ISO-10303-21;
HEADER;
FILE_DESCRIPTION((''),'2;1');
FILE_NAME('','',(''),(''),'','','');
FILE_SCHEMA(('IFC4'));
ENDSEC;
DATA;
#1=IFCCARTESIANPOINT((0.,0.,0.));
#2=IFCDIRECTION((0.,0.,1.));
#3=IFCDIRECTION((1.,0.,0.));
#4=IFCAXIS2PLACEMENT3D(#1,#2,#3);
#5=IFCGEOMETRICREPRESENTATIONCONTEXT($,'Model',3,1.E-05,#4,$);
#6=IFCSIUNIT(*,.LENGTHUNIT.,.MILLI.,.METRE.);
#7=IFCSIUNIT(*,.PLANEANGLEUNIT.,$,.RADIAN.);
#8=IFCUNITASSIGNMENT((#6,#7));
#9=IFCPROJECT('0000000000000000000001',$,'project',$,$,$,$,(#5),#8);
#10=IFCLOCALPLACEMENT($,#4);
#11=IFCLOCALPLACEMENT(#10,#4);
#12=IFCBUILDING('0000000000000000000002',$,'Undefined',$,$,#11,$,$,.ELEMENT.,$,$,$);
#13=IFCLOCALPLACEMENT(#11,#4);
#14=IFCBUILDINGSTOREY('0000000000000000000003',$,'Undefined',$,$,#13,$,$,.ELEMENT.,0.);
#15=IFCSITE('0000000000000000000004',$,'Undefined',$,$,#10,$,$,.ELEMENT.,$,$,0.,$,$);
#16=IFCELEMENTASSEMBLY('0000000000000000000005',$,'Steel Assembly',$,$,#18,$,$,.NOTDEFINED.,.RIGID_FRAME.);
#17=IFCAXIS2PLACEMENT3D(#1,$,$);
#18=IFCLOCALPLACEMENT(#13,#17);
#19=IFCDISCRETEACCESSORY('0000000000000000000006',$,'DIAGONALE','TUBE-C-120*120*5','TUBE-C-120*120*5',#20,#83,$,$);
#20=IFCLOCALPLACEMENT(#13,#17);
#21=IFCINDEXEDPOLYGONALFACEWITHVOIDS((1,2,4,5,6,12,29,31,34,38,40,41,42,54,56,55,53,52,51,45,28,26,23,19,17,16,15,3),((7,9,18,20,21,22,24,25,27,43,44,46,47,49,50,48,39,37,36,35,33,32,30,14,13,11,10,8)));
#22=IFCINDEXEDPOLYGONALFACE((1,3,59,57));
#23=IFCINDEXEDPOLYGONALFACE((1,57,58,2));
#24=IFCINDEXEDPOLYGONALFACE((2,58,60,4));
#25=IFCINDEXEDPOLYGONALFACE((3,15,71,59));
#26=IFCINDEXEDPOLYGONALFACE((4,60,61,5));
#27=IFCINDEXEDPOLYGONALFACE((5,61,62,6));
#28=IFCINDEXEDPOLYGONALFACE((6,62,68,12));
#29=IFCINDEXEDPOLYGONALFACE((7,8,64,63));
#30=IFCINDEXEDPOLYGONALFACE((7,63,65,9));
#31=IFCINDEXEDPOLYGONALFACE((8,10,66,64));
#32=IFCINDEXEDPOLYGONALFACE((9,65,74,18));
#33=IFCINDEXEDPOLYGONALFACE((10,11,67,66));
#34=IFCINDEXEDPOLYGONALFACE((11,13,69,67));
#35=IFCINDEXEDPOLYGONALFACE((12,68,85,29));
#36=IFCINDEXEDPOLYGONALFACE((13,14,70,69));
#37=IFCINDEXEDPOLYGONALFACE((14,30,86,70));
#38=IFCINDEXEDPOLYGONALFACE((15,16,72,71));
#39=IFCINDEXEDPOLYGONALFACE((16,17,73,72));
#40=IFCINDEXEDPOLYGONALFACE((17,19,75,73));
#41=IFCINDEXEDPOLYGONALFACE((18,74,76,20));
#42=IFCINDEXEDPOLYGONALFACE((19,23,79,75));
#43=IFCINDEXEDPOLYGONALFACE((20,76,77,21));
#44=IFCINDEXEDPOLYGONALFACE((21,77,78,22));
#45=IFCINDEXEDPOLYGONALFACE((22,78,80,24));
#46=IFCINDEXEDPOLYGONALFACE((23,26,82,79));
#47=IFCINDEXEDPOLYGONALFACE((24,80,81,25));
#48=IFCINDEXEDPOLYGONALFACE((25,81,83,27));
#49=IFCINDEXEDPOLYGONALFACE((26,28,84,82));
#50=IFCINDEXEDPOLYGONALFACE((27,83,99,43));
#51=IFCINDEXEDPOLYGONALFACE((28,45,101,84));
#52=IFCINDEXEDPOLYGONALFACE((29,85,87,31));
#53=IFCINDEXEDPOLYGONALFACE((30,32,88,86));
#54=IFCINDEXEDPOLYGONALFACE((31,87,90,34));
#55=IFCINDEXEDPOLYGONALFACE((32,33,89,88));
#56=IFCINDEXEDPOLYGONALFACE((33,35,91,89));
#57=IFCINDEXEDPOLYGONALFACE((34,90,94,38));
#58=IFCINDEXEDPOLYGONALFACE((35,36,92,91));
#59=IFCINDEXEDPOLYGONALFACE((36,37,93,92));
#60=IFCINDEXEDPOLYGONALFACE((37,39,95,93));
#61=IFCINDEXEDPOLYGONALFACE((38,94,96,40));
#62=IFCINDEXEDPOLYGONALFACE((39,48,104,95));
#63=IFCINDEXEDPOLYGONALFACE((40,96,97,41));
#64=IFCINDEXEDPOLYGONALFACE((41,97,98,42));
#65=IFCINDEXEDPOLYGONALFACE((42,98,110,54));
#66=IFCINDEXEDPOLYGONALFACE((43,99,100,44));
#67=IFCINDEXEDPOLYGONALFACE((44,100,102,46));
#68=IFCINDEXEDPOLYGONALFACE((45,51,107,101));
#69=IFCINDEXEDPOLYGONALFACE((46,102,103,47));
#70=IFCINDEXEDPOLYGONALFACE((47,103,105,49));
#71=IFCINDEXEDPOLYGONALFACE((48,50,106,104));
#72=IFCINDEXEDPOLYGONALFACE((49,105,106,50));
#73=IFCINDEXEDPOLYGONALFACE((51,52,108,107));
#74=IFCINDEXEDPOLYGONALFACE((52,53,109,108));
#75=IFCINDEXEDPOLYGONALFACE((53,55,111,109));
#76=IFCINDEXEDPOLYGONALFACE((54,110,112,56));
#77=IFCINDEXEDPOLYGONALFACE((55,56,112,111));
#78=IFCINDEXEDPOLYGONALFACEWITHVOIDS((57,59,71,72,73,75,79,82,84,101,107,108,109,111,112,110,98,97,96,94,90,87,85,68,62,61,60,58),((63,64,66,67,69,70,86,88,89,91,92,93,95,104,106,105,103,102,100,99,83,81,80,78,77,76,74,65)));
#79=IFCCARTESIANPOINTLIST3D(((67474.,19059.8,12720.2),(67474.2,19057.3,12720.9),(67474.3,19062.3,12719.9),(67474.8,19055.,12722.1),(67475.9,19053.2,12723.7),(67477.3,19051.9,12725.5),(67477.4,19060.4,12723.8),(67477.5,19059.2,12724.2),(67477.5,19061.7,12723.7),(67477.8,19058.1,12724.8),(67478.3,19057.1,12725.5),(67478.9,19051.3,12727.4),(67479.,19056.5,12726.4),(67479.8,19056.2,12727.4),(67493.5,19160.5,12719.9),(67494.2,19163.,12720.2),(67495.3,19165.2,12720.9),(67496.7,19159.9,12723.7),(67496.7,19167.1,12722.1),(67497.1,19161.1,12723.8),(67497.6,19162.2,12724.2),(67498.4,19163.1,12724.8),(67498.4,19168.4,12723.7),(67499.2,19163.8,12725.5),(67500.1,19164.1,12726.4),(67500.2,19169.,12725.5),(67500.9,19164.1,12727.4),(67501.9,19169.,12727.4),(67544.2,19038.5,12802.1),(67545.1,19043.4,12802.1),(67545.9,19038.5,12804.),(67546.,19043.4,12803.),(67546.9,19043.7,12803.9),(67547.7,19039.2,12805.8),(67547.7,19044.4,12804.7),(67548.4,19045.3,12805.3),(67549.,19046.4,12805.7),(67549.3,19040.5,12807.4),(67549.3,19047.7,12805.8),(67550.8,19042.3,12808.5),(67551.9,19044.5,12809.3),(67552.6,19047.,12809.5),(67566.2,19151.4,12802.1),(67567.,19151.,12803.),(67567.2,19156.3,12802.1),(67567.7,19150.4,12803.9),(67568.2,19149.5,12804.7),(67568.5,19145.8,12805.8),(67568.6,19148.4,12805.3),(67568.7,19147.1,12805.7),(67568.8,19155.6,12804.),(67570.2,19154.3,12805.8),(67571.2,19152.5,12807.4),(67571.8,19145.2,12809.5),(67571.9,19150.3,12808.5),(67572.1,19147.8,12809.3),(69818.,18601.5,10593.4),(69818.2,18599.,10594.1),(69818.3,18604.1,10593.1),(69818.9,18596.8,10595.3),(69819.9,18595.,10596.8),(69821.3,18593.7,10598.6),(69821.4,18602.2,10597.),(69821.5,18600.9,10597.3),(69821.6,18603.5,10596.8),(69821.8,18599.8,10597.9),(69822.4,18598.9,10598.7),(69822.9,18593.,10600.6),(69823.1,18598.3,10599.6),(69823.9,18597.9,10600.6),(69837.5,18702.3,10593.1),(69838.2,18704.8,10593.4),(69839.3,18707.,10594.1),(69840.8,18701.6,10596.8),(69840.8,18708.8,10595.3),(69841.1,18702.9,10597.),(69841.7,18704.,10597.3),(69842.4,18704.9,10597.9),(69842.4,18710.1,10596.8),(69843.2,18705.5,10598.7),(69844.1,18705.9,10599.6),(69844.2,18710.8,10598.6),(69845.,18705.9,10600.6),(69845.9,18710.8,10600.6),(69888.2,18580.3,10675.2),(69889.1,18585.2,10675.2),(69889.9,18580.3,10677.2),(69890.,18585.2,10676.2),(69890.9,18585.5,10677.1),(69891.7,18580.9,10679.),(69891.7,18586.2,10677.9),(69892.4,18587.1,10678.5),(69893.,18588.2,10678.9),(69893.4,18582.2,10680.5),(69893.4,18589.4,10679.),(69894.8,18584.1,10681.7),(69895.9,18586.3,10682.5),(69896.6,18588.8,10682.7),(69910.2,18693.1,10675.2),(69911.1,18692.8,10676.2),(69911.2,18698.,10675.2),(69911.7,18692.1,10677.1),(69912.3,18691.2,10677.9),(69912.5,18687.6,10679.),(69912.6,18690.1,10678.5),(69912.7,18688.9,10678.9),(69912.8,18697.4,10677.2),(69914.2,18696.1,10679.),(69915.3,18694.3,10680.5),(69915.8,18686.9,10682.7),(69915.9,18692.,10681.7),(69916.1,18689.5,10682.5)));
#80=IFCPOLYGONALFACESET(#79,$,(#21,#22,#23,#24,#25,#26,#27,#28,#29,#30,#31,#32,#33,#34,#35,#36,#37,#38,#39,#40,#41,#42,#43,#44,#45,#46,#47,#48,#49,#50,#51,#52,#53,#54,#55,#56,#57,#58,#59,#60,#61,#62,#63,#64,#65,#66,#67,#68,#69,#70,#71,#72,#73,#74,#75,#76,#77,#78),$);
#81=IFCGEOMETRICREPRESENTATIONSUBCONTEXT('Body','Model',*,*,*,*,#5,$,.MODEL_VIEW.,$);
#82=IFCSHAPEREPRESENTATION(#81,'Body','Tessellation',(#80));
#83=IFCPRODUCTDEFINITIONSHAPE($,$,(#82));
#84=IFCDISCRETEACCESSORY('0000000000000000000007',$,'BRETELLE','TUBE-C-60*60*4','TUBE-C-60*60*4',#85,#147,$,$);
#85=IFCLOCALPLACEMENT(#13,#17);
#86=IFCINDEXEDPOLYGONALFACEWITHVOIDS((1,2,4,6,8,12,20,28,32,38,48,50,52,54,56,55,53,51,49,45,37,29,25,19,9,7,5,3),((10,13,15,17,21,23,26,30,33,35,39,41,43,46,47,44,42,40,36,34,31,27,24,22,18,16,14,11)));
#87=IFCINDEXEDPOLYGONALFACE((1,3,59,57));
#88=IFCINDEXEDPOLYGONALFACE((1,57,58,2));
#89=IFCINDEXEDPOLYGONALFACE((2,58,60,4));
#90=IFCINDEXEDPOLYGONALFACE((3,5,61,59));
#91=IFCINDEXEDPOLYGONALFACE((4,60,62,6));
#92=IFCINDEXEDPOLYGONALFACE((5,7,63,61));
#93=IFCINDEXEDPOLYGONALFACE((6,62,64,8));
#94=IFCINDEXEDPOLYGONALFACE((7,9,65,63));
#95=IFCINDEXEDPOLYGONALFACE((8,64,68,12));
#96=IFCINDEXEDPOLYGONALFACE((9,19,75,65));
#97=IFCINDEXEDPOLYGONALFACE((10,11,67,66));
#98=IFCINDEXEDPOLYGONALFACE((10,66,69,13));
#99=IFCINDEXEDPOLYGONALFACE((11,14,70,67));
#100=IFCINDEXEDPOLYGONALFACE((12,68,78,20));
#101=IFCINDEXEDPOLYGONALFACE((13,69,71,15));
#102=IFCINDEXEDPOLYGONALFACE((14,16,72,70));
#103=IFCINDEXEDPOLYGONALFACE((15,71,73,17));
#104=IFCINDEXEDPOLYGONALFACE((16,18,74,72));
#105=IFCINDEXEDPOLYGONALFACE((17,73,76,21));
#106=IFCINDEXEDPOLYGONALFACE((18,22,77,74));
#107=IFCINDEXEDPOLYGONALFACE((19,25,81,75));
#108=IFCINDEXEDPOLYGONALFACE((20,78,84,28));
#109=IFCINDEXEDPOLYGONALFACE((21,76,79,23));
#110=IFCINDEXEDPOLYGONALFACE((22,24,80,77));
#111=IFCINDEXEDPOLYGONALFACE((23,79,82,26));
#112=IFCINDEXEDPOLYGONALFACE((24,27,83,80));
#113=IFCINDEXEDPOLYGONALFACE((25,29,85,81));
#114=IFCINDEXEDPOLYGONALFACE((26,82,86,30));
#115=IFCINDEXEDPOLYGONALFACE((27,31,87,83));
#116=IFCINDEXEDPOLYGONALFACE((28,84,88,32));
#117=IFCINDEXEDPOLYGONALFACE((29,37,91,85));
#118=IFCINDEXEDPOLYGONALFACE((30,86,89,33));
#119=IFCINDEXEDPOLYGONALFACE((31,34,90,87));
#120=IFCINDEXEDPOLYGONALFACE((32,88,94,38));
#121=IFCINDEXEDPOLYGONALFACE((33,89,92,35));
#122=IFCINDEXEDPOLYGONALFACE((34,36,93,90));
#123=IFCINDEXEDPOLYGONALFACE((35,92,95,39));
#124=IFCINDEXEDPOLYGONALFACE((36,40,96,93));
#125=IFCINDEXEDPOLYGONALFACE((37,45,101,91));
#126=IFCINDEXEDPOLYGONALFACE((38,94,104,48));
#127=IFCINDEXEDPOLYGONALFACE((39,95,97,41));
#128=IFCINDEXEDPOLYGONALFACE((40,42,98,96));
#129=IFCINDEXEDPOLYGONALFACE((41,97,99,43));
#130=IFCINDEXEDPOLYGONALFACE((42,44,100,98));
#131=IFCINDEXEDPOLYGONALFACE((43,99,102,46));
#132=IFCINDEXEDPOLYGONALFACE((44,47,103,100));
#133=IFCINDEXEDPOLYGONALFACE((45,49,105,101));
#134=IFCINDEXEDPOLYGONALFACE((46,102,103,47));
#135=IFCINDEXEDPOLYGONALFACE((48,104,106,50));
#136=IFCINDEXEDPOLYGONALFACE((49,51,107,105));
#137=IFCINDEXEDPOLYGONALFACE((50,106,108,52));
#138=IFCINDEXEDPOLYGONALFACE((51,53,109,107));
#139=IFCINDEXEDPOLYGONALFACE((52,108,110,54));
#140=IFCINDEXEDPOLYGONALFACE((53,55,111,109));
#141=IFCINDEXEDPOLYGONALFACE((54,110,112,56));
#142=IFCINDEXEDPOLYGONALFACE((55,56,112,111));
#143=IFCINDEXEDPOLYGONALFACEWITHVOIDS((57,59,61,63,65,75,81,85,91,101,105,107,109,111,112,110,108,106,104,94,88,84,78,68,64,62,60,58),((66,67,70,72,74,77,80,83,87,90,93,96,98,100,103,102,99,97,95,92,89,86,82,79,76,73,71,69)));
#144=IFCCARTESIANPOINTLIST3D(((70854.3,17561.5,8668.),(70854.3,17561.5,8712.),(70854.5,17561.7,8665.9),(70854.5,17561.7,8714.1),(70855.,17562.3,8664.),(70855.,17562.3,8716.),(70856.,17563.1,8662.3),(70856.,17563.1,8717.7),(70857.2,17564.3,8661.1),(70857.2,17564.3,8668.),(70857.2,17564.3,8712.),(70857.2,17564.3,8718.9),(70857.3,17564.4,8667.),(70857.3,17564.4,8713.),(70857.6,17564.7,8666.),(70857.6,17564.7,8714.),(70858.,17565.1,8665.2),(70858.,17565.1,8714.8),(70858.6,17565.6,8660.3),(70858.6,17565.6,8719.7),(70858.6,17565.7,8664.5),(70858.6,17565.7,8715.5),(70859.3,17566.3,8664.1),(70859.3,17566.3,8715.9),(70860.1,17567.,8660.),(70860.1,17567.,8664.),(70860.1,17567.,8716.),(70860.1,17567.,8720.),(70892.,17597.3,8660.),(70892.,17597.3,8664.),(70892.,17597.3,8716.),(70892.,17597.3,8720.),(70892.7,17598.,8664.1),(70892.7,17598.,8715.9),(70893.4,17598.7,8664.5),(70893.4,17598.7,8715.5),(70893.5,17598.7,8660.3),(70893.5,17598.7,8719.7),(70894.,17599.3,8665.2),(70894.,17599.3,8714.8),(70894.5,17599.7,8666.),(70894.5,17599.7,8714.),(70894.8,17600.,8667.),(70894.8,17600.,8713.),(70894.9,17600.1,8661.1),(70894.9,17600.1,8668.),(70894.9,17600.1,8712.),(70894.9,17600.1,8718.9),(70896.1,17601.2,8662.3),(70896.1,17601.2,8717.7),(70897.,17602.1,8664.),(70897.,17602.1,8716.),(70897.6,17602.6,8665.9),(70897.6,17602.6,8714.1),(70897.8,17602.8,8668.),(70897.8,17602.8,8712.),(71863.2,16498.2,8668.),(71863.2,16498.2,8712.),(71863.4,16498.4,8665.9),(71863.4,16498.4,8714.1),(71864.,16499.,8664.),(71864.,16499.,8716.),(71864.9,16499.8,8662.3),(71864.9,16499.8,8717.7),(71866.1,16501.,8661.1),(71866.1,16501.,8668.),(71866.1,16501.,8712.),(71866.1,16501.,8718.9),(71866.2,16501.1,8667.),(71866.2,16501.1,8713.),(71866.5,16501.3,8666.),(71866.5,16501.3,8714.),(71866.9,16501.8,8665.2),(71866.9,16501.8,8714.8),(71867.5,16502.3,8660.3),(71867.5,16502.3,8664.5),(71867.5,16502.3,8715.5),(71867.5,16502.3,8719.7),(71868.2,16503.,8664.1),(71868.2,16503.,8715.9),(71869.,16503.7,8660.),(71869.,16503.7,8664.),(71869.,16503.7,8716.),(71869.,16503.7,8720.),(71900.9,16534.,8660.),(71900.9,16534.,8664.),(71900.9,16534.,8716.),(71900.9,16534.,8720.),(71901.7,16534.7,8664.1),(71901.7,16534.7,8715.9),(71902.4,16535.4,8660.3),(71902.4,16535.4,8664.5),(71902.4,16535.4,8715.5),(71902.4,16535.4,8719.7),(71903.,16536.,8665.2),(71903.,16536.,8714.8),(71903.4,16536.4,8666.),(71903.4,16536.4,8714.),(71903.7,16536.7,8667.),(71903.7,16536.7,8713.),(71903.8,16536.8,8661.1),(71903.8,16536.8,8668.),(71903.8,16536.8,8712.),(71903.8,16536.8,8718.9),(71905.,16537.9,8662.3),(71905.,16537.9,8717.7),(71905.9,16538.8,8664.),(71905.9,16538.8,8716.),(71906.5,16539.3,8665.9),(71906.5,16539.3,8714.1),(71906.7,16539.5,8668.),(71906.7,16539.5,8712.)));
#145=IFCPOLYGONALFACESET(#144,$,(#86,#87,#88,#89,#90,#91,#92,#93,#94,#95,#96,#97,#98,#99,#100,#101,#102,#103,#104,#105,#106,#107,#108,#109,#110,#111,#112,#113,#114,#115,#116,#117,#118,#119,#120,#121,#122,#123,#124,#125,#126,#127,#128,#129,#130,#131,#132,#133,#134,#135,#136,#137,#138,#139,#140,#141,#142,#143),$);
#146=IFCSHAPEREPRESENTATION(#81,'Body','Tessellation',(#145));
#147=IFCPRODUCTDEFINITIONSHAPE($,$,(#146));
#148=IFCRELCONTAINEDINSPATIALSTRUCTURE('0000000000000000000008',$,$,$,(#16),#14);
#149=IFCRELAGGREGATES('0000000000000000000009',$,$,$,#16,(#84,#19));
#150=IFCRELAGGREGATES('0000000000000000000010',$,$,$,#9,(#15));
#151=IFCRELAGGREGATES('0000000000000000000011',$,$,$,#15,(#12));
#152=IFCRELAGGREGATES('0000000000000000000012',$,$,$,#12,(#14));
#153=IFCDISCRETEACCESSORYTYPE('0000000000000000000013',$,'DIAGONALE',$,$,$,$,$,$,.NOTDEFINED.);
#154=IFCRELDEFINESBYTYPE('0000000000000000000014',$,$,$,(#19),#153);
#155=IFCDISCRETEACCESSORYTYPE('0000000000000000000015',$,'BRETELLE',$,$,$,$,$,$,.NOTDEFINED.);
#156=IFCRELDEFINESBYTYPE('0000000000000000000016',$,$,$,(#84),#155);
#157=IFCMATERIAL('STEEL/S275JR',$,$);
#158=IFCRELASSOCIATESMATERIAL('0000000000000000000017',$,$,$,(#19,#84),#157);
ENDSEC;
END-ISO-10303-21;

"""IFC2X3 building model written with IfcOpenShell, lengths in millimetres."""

from ifc_helpers import new_model, si_unit, frame, origin_with_axes, origin_2d_with_axis, place, context, subcontext, project, spatial, hollow_rectangle, extrude, material, type_object, element, aggregate, save


model = new_model("IFC2X3")

# Units and contexts
model_context = context("Model", 3, precision=1e-05, world=origin_with_axes())
body_context = subcontext(model_context, "Body", "Model", "MODEL_VIEW")
ifc_project = project(units=[si_unit("LENGTHUNIT", "METRE", prefix="MILLI"), si_unit("PLANEANGLEUNIT", "RADIAN")], contexts=[model_context])

# Site, building, storey
site_placement = place(None, origin_with_axes())
site = spatial("IfcSite", under=ifc_project, at=site_placement, Name="Undefined", CompositionType="ELEMENT", RefElevation=0.0)
building_placement = place(site_placement, origin_with_axes())
building = spatial("IfcBuilding", under=site, at=building_placement, Name="Undefined", CompositionType="ELEMENT")
storey_placement = place(building_placement, origin_with_axes())
storey = spatial("IfcBuildingStorey", under=building, at=storey_placement, Name="Undefined", CompositionType="ELEMENT", Elevation=0.0)

# Shared definitions
ifc_material = material(Name="STEEL/S275JR")

# Element assembly, discrete accessories
assembly_1_placement = place(storey_placement, origin_with_axes())
assembly_1 = element("IfcElementAssembly", 1, at=assembly_1_placement, inside=storey, Name="Steel Assembly", AssemblyPlace="NOTDEFINED", PredefinedType="RIGID_FRAME")
discrete_accessory_type_1 = type_object("IfcDiscreteAccessoryType", Name="DIAGONALE")
discrete_accessory_1_placement = place(assembly_1_placement, frame((69867.1, 18645.5, 10637.9), z_axis=(-0.652674, 0.127592, -0.746818), x_axis=(-0.732944, 0.143284, 0.665028)))
discrete_accessory_1 = element("IfcDiscreteAccessory", 2, at=discrete_accessory_1_placement, type_object=discrete_accessory_type_1, material=ifc_material, Name="DIAGONALE", Description="TUBE-C-120*120*5", ObjectType="TUBE-C-120*120*5", context=body_context, shape_type="SweptSolid", body=[
    extrude(hollow_rectangle(XDim=120.0, YDim=120.0, WallThickness=5.0, InnerFilletRadius=5.0, OuterFilletRadius=10.0, at=origin_2d_with_axis()), frame((3198.1, 0.0, 0.0), z_axis=(-1.0, 0.0, 0.0), x_axis=(0.0, -1.0, 0.0)), (0.0, 0.0, 1.0), 3198.1),
])
discrete_accessory_type_2 = type_object("IfcDiscreteAccessoryType", Name="BRETELLE")
discrete_accessory_2_placement = place(assembly_1_placement, frame((70876.0, 17582.2, 8690.0), z_axis=(0.725415, 0.688312, 0.0), x_axis=(0.688312, -0.725415, 0.0)))
discrete_accessory_2 = element("IfcDiscreteAccessory", 3, at=discrete_accessory_2_placement, type_object=discrete_accessory_type_2, material=ifc_material, Name="BRETELLE", Description="TUBE-C-60*60*4", ObjectType="TUBE-C-60*60*4", context=body_context, shape_type="SweptSolid", body=[
    extrude(hollow_rectangle(XDim=60.0, YDim=60.0, WallThickness=4.0, InnerFilletRadius=4.0, OuterFilletRadius=8.0, at=origin_2d_with_axis()), frame((1465.8, 0.0, 0.0), z_axis=(-1.0, 0.0, 0.0), x_axis=(0.0, -1.0, 0.0)), (0.0, 0.0, 1.0), 1465.8),
])
aggregate(assembly_1, [discrete_accessory_2, discrete_accessory_1])

save(model, "model.ifc")
